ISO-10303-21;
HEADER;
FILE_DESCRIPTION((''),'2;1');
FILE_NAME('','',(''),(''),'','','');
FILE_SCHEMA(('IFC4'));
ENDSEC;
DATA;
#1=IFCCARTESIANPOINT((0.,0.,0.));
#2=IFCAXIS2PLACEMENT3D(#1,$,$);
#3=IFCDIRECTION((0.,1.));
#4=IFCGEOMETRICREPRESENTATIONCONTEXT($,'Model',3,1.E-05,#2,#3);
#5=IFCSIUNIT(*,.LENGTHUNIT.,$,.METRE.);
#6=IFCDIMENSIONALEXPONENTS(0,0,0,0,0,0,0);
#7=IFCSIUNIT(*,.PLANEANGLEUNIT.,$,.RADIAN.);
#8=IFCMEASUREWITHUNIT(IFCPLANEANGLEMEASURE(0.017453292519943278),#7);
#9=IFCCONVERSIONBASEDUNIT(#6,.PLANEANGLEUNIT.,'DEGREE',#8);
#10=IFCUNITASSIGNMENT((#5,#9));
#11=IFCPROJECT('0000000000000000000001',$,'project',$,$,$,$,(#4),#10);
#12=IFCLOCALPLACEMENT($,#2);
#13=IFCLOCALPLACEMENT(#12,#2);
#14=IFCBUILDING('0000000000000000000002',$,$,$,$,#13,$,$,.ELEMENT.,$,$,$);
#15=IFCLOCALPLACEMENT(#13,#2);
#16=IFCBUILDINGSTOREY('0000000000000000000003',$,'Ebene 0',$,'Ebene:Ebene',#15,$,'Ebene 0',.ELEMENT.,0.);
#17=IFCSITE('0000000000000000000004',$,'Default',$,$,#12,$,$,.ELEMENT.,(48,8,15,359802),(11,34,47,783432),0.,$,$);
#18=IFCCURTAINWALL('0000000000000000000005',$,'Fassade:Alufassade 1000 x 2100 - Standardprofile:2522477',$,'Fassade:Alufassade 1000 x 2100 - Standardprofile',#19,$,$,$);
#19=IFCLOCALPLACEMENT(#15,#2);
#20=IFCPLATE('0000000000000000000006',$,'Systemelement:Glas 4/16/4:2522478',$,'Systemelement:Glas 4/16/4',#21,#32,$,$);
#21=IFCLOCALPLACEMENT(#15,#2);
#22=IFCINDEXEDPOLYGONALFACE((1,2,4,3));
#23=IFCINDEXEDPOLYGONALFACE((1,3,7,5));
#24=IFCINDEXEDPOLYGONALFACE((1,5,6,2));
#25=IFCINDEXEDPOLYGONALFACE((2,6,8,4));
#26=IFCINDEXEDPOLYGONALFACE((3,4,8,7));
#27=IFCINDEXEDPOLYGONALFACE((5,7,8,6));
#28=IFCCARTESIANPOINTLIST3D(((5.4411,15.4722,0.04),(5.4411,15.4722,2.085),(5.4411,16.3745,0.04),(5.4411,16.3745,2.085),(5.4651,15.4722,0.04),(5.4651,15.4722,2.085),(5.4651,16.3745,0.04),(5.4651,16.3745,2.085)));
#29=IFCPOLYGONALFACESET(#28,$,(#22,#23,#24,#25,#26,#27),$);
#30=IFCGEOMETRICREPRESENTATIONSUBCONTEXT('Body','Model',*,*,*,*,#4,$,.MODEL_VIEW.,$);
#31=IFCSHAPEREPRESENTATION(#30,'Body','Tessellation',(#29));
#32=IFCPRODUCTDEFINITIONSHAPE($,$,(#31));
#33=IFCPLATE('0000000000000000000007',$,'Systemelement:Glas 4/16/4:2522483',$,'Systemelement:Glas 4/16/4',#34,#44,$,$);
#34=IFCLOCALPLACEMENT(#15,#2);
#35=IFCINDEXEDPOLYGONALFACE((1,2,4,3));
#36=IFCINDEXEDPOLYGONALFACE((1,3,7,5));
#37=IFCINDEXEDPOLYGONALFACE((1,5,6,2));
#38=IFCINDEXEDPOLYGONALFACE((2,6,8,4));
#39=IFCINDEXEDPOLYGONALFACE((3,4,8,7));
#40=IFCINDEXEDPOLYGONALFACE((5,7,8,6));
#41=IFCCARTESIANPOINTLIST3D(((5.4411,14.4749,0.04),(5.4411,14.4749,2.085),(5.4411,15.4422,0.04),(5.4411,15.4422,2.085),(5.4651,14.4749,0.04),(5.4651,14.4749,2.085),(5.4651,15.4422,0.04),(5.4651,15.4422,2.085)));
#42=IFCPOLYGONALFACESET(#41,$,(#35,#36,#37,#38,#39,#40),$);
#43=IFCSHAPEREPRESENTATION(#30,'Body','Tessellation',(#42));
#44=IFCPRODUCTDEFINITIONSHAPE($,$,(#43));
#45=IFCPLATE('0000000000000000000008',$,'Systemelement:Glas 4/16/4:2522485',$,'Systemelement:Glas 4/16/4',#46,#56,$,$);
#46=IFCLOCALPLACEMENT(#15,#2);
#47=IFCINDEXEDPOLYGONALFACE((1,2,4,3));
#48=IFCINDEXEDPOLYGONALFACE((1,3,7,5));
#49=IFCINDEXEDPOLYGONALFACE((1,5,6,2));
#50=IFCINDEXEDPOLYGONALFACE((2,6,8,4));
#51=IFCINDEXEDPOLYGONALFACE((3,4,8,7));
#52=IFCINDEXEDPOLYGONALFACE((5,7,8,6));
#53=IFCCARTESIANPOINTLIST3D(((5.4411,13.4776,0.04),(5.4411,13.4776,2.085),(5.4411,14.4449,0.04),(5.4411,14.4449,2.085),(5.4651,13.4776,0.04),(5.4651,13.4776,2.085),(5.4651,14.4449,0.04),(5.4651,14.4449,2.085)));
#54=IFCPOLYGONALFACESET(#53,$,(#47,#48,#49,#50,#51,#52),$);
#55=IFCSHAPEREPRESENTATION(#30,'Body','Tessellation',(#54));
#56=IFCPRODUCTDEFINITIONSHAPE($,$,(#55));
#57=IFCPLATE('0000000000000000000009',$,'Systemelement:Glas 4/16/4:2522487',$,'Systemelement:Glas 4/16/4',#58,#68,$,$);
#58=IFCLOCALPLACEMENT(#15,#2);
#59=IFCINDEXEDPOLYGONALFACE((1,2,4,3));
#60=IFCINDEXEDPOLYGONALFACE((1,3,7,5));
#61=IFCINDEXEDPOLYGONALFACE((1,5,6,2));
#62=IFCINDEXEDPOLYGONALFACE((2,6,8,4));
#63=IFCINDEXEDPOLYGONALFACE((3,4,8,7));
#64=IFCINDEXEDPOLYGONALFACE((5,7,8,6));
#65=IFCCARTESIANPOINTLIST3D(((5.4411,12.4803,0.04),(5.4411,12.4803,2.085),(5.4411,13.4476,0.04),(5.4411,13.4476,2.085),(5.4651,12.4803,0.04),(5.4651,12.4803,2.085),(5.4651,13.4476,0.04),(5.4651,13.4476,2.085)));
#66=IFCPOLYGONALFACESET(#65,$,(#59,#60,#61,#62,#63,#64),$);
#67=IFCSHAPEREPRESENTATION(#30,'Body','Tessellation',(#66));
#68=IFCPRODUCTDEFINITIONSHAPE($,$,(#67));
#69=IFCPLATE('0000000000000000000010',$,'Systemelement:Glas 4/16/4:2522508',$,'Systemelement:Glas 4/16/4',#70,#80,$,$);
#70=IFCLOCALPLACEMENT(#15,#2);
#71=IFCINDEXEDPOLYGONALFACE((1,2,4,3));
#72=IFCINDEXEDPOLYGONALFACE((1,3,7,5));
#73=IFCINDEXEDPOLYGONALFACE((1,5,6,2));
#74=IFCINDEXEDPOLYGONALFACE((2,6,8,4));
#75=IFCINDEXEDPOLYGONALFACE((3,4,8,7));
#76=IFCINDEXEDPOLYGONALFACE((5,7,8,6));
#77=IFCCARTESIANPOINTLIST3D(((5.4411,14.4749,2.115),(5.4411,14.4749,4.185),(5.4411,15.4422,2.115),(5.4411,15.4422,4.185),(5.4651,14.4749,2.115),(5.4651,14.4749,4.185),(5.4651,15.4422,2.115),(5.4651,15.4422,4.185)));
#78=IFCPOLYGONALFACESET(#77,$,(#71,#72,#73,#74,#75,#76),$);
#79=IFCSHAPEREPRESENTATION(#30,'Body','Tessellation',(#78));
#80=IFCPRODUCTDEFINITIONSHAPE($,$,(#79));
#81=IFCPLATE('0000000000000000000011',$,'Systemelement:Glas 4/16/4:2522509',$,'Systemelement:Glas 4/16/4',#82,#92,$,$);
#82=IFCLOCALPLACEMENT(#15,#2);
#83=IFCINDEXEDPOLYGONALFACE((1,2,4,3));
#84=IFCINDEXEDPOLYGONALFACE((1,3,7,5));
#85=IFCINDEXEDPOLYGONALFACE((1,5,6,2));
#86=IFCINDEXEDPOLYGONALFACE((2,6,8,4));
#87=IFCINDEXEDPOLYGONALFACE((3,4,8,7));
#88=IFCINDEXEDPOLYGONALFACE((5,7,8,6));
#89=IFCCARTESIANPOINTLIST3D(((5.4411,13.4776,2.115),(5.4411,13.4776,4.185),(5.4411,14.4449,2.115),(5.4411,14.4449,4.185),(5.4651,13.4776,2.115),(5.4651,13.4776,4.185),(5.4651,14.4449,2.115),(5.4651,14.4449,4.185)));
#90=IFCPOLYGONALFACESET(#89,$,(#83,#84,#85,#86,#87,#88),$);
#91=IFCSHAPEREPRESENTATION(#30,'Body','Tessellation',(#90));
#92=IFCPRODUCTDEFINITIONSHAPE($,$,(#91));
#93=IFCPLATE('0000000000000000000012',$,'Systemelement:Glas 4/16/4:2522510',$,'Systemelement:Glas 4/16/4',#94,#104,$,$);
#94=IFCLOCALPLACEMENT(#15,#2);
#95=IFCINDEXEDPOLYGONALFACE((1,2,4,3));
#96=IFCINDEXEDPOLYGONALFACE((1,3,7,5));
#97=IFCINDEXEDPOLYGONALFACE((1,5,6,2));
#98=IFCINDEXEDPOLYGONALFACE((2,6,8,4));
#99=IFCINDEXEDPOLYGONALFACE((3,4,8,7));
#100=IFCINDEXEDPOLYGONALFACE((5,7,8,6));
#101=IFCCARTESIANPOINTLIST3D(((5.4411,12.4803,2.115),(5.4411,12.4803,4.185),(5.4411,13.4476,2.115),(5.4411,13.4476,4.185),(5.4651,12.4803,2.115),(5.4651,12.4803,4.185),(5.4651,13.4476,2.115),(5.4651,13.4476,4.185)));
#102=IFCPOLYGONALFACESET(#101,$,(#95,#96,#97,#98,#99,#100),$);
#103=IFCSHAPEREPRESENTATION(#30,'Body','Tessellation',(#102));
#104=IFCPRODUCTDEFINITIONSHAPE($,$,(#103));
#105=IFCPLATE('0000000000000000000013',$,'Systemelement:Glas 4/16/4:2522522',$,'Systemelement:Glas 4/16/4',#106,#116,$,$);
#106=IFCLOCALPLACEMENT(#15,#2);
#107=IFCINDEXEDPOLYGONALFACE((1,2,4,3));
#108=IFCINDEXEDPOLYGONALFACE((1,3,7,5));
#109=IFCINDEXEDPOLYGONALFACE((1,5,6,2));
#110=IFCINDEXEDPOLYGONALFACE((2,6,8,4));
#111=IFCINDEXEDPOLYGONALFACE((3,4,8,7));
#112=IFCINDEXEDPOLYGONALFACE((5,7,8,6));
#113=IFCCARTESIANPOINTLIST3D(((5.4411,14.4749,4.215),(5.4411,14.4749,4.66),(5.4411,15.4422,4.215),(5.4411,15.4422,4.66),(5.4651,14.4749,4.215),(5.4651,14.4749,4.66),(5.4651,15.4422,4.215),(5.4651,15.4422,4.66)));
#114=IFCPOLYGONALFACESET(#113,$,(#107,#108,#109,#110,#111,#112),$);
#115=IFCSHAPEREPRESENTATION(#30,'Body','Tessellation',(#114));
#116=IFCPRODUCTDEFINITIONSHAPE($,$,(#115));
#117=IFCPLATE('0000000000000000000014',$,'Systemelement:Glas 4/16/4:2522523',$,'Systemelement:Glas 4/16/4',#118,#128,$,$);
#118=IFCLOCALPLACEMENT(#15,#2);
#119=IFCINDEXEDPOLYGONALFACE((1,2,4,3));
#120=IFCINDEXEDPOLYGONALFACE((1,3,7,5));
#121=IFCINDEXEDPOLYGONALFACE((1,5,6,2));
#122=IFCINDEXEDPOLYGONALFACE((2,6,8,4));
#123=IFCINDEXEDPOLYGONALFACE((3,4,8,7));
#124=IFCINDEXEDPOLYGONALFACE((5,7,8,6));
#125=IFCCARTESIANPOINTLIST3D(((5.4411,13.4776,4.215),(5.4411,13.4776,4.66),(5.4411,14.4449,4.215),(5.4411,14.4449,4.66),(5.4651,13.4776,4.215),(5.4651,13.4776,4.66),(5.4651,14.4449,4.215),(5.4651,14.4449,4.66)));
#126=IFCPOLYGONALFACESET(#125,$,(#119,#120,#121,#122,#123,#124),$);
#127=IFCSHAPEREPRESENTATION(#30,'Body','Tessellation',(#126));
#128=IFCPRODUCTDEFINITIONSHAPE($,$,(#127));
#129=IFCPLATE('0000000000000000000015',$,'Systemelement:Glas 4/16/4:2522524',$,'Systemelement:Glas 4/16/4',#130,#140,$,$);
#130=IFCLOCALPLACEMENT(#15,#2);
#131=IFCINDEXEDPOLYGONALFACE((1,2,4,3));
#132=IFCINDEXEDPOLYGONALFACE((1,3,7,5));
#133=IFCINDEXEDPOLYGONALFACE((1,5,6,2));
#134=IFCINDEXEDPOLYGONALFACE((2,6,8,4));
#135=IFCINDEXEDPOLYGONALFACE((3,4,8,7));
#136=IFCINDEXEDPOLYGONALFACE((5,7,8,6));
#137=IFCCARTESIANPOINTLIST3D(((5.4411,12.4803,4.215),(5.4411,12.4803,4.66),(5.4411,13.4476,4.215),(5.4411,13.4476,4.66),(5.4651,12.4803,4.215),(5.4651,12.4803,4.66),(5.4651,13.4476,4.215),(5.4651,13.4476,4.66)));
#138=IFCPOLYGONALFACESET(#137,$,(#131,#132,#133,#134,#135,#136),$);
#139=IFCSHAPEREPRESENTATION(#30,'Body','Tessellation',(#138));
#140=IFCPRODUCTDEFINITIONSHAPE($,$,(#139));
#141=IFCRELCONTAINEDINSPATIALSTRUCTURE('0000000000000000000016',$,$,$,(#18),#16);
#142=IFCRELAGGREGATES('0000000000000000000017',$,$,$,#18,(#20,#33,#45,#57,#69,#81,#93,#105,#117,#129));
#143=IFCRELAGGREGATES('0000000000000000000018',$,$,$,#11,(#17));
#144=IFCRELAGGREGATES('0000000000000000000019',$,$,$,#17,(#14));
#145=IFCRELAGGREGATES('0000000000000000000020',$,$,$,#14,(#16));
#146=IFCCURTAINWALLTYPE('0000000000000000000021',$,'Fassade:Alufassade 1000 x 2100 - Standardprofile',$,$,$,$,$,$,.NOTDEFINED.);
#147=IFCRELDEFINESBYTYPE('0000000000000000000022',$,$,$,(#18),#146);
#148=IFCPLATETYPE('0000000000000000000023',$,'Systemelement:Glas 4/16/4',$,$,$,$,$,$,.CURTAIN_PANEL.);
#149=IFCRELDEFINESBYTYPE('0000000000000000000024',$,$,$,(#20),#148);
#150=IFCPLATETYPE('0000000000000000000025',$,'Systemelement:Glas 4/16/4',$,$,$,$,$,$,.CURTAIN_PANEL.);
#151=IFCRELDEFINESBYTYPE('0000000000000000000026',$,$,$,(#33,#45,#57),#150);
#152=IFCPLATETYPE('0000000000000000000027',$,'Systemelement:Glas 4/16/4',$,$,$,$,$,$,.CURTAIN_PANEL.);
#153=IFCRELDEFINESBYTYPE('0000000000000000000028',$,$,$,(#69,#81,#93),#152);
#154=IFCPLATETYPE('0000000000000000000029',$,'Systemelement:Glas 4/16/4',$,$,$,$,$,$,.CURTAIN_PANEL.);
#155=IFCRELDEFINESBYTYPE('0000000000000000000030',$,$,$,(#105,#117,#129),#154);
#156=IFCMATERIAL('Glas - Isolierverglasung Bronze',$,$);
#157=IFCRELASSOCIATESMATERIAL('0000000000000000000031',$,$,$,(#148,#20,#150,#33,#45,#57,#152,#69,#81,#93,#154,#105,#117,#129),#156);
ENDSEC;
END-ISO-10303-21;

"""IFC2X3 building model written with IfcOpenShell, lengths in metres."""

from ifc_helpers import new_model, entity, si_unit, converted_unit, direction, frame, origin, origin_2d_with_axis, place, context, subcontext, project, spatial, rectangle, extrude, source, transform, mapped, material, type_object, type_shapes, element, aggregate, save


model = new_model("IFC2X3")

# Units and contexts
model_context = context("Model", 3, precision=1e-05, world=origin(), true_north=direction((0.0, 1.0)))
body_context = subcontext(model_context, "Body", "Model", "MODEL_VIEW")
ifc_project = project(units=[si_unit("LENGTHUNIT", "METRE"), converted_unit("PLANEANGLEUNIT", "DEGREE", entity("IfcPlaneAngleMeasure", 0.017453292519943278), si_unit("PLANEANGLEUNIT", "RADIAN"), dimensions=[0, 0, 0, 0, 0, 0, 0])], contexts=[model_context])

# Site, building, storey
site_placement = place(None, origin())
site = spatial("IfcSite", under=ifc_project, at=site_placement, Name="Default", CompositionType="ELEMENT", RefLatitude=(48, 8, 15, 359802), RefLongitude=(11, 34, 47, 783432), RefElevation=0.0)
building_placement = place(site_placement, origin())
building = spatial("IfcBuilding", under=site, at=building_placement, CompositionType="ELEMENT")
storey_placement = place(building_placement, origin())
storey = spatial("IfcBuildingStorey", under=building, at=storey_placement, Name="Ebene 0", ObjectType="Ebene:Ebene", LongName="Ebene 0", CompositionType="ELEMENT", Elevation=0.0)

# Curtain wall, plates
curtain_wall_type = type_object("IfcCurtainWallType", Name="Fassade:Alufassade 1000 x 2100 - Standardprofile", PredefinedType="NOTDEFINED")
curtain_wall_placement = place(storey_placement, origin())
curtain_wall = element("IfcCurtainWall", 1, at=curtain_wall_placement, inside=storey, type_object=curtain_wall_type, Name="Fassade:Alufassade 1000 x 2100 - Standardprofile:2522477", ObjectType="Fassade:Alufassade 1000 x 2100 - Standardprofile")
ifc_material_1 = material(Name="Glas - Isolierverglasung Bronze")
plate_type_1 = type_object("IfcPlateType", Name="Systemelement:Glas 4/16/4", PredefinedType="CURTAIN_PANEL", material=ifc_material_1)
shared_shape_1 = source(origin(), body_context, "Body", "SweptSolid", [
    extrude(rectangle(XDim=0.024, YDim=0.9023, at=origin_2d_with_axis()), frame((0.0, 0.0, 0.0), z_axis=(0.0, 0.0, 1.0), x_axis=(0.0, 1.0, 0.0)), (0.0, 0.0, 1.0), 2.045),
])
type_shapes(plate_type_1, [shared_shape_1])
plate_1_placement = place(curtain_wall_placement, frame((5.4531, 15.9233, 0.04), z_axis=(0.0, 0.0, 1.0), x_axis=(0.0, -1.0, 0.0)))
plate_1 = element("IfcPlate", 2, at=plate_1_placement, type_object=plate_type_1, material=ifc_material_1, Name="Systemelement:Glas 4/16/4:2522478", ObjectType="Systemelement:Glas 4/16/4", context=body_context, shape_type="MappedRepresentation", body=[
    mapped(shared_shape_1, transform((0.0, 0.0, 0.0), scale=1.0)),
])
plate_type_2 = type_object("IfcPlateType", Name="Systemelement:Glas 4/16/4", PredefinedType="CURTAIN_PANEL", material=ifc_material_1)
shared_shape_2 = source(origin(), body_context, "Body", "SweptSolid", [
    extrude(rectangle(XDim=0.024, YDim=0.9673, at=origin_2d_with_axis()), frame((0.0, 0.0, 0.0), z_axis=(0.0, 0.0, 1.0), x_axis=(0.0, 1.0, 0.0)), (0.0, 0.0, 1.0), 2.045),
])
type_shapes(plate_type_2, [shared_shape_2])
plate_2_placement = place(curtain_wall_placement, frame((5.4531, 14.9585, 0.04), z_axis=(0.0, 0.0, 1.0), x_axis=(0.0, -1.0, 0.0)))
plate_2 = element("IfcPlate", 3, at=plate_2_placement, type_object=plate_type_2, material=ifc_material_1, Name="Systemelement:Glas 4/16/4:2522483", ObjectType="Systemelement:Glas 4/16/4", context=body_context, shape_type="MappedRepresentation", body=[
    mapped(shared_shape_2, transform((0.0, 0.0, 0.0), scale=1.0)),
])
plate_3_placement = place(curtain_wall_placement, frame((5.4531, 13.9612, 0.04), z_axis=(0.0, 0.0, 1.0), x_axis=(0.0, -1.0, 0.0)))
plate_3 = element("IfcPlate", 4, at=plate_3_placement, type_object=plate_type_2, material=ifc_material_1, Name="Systemelement:Glas 4/16/4:2522485", ObjectType="Systemelement:Glas 4/16/4", context=body_context, shape_type="MappedRepresentation", body=[
    mapped(shared_shape_2, transform((0.0, 0.0, 0.0), scale=1.0)),
])
plate_4_placement = place(curtain_wall_placement, frame((5.4531, 12.9639, 0.04), z_axis=(0.0, 0.0, 1.0), x_axis=(0.0, -1.0, 0.0)))
plate_4 = element("IfcPlate", 5, at=plate_4_placement, type_object=plate_type_2, material=ifc_material_1, Name="Systemelement:Glas 4/16/4:2522487", ObjectType="Systemelement:Glas 4/16/4", context=body_context, shape_type="MappedRepresentation", body=[
    mapped(shared_shape_2, transform((0.0, 0.0, 0.0), scale=1.0)),
])
plate_type_3 = type_object("IfcPlateType", Name="Systemelement:Glas 4/16/4", PredefinedType="CURTAIN_PANEL", material=ifc_material_1)
shared_shape_3 = source(origin(), body_context, "Body", "SweptSolid", [
    extrude(rectangle(XDim=0.024, YDim=0.9673, at=origin_2d_with_axis()), frame((0.0, 0.0, 0.0), z_axis=(0.0, 0.0, 1.0), x_axis=(0.0, 1.0, 0.0)), (0.0, 0.0, 1.0), 2.07),
])
type_shapes(plate_type_3, [shared_shape_3])
plate_5_placement = place(curtain_wall_placement, frame((5.4531, 14.9585, 2.115), z_axis=(0.0, 0.0, 1.0), x_axis=(0.0, -1.0, 0.0)))
plate_5 = element("IfcPlate", 6, at=plate_5_placement, type_object=plate_type_3, material=ifc_material_1, Name="Systemelement:Glas 4/16/4:2522508", ObjectType="Systemelement:Glas 4/16/4", context=body_context, shape_type="MappedRepresentation", body=[
    mapped(shared_shape_3, transform((0.0, 0.0, 0.0), scale=1.0)),
])
plate_6_placement = place(curtain_wall_placement, frame((5.4531, 13.9612, 2.115), z_axis=(0.0, 0.0, 1.0), x_axis=(0.0, -1.0, 0.0)))
plate_6 = element("IfcPlate", 7, at=plate_6_placement, type_object=plate_type_3, material=ifc_material_1, Name="Systemelement:Glas 4/16/4:2522509", ObjectType="Systemelement:Glas 4/16/4", context=body_context, shape_type="MappedRepresentation", body=[
    mapped(shared_shape_3, transform((0.0, 0.0, 0.0), scale=1.0)),
])
plate_7_placement = place(curtain_wall_placement, frame((5.4531, 12.9639, 2.115), z_axis=(0.0, 0.0, 1.0), x_axis=(0.0, -1.0, 0.0)))
plate_7 = element("IfcPlate", 8, at=plate_7_placement, type_object=plate_type_3, material=ifc_material_1, Name="Systemelement:Glas 4/16/4:2522510", ObjectType="Systemelement:Glas 4/16/4", context=body_context, shape_type="MappedRepresentation", body=[
    mapped(shared_shape_3, transform((0.0, 0.0, 0.0), scale=1.0)),
])
plate_type_4 = type_object("IfcPlateType", Name="Systemelement:Glas 4/16/4", PredefinedType="CURTAIN_PANEL", material=ifc_material_1)
shared_shape_4 = source(origin(), body_context, "Body", "SweptSolid", [
    extrude(rectangle(XDim=0.024, YDim=0.9673, at=origin_2d_with_axis()), frame((0.0, 0.0, 0.0), z_axis=(0.0, 0.0, 1.0), x_axis=(0.0, 1.0, 0.0)), (0.0, 0.0, 1.0), 0.445),
])
type_shapes(plate_type_4, [shared_shape_4])
plate_8_placement = place(curtain_wall_placement, frame((5.4531, 14.9585, 4.215), z_axis=(0.0, 0.0, 1.0), x_axis=(0.0, -1.0, 0.0)))
plate_8 = element("IfcPlate", 9, at=plate_8_placement, type_object=plate_type_4, material=ifc_material_1, Name="Systemelement:Glas 4/16/4:2522522", ObjectType="Systemelement:Glas 4/16/4", context=body_context, shape_type="MappedRepresentation", body=[
    mapped(shared_shape_4, transform((0.0, 0.0, 0.0), scale=1.0)),
])
plate_9_placement = place(curtain_wall_placement, frame((5.4531, 13.9612, 4.215), z_axis=(0.0, 0.0, 1.0), x_axis=(0.0, -1.0, 0.0)))
plate_9 = element("IfcPlate", 10, at=plate_9_placement, type_object=plate_type_4, material=ifc_material_1, Name="Systemelement:Glas 4/16/4:2522523", ObjectType="Systemelement:Glas 4/16/4", context=body_context, shape_type="MappedRepresentation", body=[
    mapped(shared_shape_4, transform((0.0, 0.0, 0.0), scale=1.0)),
])
plate_10_placement = place(curtain_wall_placement, frame((5.4531, 12.9639, 4.215), z_axis=(0.0, 0.0, 1.0), x_axis=(0.0, -1.0, 0.0)))
plate_10 = element("IfcPlate", 11, at=plate_10_placement, type_object=plate_type_4, material=ifc_material_1, Name="Systemelement:Glas 4/16/4:2522524", ObjectType="Systemelement:Glas 4/16/4", context=body_context, shape_type="MappedRepresentation", body=[
    mapped(shared_shape_4, transform((0.0, 0.0, 0.0), scale=1.0)),
])
aggregate(curtain_wall, [plate_1, plate_2, plate_3, plate_4, plate_5, plate_6, plate_7, plate_8, plate_9, plate_10])

save(model, "model.ifc")
